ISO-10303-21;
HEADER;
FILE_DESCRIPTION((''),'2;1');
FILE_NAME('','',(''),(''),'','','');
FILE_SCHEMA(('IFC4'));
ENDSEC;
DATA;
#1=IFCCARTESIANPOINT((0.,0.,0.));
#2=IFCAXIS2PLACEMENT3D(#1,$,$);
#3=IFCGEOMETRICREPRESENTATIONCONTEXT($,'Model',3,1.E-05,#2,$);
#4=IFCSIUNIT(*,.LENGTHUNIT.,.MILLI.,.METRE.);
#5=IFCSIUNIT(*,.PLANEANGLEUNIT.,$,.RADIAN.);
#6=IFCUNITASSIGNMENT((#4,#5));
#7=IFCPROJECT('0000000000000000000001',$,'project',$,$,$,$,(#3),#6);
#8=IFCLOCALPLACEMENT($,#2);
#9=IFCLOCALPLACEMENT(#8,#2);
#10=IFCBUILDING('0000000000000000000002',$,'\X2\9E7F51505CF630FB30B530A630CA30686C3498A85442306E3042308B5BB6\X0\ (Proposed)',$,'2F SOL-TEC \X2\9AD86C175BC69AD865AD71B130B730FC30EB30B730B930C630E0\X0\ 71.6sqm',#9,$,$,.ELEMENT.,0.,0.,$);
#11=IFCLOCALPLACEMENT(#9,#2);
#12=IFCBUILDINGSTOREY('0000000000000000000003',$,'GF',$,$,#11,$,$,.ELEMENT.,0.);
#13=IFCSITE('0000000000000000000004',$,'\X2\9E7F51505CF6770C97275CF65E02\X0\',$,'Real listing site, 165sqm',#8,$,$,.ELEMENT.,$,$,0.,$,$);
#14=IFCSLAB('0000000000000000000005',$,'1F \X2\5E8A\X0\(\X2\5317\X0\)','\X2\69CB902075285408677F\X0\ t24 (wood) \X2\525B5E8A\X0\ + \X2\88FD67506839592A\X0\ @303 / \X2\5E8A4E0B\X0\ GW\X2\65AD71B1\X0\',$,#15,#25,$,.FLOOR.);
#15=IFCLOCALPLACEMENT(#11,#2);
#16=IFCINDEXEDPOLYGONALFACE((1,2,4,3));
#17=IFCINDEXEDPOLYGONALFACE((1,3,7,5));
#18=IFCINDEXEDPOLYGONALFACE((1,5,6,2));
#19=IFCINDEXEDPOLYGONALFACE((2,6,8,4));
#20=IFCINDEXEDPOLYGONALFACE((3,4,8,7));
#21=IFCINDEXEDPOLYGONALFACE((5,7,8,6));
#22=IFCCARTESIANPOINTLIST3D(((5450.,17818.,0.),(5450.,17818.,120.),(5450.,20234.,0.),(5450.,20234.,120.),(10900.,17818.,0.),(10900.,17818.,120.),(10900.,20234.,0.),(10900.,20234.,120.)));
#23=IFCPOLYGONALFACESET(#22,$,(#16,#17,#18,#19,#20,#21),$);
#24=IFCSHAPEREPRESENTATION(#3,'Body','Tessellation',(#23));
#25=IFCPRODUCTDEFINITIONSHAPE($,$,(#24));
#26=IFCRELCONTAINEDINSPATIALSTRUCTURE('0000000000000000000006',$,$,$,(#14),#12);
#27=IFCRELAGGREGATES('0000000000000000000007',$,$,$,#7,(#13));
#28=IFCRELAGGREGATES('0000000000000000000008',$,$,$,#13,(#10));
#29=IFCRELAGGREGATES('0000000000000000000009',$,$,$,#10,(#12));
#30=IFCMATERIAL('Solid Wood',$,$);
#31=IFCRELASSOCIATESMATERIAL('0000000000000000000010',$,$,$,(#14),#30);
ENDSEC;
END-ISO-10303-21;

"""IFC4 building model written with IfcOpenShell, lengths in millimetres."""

from ifc_helpers import new_model, si_unit, frame, frame_2d, origin, place, context, project, spatial, rectangle, extrude, material, element, save


model = new_model("IFC4")

# Units and contexts
model_context = context("Model", 3, precision=1e-05, world=origin())
ifc_project = project(units=[si_unit("LENGTHUNIT", "METRE", prefix="MILLI"), si_unit("PLANEANGLEUNIT", "RADIAN")], contexts=[model_context])

# Site, building, storey
site_placement = place(None, origin())
site = spatial("IfcSite", under=ifc_project, at=site_placement, Name="鹿児島県霧島市", ObjectType="Real listing site, 165sqm", CompositionType="ELEMENT", RefElevation=0.0)
building_placement = place(site_placement, origin())
building = spatial("IfcBuilding", under=site, at=building_placement, Name="鹿児島・サウナと水風呂のある家 (Proposed)", ObjectType="2F SOL-TEC 高気密高断熱シールシステム 71.6sqm", CompositionType="ELEMENT", ElevationOfRefHeight=0.0, ElevationOfTerrain=0.0)
storey_placement = place(building_placement, origin())
storey = spatial("IfcBuildingStorey", under=building, at=storey_placement, Name="GF", CompositionType="ELEMENT", Elevation=0.0)

# Shared definitions
ifc_material_1 = material(Name="Solid Wood")

# Slab
slab_placement = place(storey_placement, frame((2725.0, 8909.0, 0.0)))
element("IfcSlab", 1, at=slab_placement, inside=storey, material=ifc_material_1, Name="1F 床(北)", Description="構造用合板 t24 (wood) 剛床 + 製材根太 @303 / 床下 GW断熱", PredefinedType="FLOOR", context=model_context, shape_type="SweptSolid", body=[
    extrude(rectangle(XDim=5450.0, YDim=2416.0, at=frame_2d((2725.0, 1208.0))), frame((2725.0, 8909.0, 0.0)), (0.0, 0.0, 1.0), 120.0),
])

save(model, "model.ifc")
